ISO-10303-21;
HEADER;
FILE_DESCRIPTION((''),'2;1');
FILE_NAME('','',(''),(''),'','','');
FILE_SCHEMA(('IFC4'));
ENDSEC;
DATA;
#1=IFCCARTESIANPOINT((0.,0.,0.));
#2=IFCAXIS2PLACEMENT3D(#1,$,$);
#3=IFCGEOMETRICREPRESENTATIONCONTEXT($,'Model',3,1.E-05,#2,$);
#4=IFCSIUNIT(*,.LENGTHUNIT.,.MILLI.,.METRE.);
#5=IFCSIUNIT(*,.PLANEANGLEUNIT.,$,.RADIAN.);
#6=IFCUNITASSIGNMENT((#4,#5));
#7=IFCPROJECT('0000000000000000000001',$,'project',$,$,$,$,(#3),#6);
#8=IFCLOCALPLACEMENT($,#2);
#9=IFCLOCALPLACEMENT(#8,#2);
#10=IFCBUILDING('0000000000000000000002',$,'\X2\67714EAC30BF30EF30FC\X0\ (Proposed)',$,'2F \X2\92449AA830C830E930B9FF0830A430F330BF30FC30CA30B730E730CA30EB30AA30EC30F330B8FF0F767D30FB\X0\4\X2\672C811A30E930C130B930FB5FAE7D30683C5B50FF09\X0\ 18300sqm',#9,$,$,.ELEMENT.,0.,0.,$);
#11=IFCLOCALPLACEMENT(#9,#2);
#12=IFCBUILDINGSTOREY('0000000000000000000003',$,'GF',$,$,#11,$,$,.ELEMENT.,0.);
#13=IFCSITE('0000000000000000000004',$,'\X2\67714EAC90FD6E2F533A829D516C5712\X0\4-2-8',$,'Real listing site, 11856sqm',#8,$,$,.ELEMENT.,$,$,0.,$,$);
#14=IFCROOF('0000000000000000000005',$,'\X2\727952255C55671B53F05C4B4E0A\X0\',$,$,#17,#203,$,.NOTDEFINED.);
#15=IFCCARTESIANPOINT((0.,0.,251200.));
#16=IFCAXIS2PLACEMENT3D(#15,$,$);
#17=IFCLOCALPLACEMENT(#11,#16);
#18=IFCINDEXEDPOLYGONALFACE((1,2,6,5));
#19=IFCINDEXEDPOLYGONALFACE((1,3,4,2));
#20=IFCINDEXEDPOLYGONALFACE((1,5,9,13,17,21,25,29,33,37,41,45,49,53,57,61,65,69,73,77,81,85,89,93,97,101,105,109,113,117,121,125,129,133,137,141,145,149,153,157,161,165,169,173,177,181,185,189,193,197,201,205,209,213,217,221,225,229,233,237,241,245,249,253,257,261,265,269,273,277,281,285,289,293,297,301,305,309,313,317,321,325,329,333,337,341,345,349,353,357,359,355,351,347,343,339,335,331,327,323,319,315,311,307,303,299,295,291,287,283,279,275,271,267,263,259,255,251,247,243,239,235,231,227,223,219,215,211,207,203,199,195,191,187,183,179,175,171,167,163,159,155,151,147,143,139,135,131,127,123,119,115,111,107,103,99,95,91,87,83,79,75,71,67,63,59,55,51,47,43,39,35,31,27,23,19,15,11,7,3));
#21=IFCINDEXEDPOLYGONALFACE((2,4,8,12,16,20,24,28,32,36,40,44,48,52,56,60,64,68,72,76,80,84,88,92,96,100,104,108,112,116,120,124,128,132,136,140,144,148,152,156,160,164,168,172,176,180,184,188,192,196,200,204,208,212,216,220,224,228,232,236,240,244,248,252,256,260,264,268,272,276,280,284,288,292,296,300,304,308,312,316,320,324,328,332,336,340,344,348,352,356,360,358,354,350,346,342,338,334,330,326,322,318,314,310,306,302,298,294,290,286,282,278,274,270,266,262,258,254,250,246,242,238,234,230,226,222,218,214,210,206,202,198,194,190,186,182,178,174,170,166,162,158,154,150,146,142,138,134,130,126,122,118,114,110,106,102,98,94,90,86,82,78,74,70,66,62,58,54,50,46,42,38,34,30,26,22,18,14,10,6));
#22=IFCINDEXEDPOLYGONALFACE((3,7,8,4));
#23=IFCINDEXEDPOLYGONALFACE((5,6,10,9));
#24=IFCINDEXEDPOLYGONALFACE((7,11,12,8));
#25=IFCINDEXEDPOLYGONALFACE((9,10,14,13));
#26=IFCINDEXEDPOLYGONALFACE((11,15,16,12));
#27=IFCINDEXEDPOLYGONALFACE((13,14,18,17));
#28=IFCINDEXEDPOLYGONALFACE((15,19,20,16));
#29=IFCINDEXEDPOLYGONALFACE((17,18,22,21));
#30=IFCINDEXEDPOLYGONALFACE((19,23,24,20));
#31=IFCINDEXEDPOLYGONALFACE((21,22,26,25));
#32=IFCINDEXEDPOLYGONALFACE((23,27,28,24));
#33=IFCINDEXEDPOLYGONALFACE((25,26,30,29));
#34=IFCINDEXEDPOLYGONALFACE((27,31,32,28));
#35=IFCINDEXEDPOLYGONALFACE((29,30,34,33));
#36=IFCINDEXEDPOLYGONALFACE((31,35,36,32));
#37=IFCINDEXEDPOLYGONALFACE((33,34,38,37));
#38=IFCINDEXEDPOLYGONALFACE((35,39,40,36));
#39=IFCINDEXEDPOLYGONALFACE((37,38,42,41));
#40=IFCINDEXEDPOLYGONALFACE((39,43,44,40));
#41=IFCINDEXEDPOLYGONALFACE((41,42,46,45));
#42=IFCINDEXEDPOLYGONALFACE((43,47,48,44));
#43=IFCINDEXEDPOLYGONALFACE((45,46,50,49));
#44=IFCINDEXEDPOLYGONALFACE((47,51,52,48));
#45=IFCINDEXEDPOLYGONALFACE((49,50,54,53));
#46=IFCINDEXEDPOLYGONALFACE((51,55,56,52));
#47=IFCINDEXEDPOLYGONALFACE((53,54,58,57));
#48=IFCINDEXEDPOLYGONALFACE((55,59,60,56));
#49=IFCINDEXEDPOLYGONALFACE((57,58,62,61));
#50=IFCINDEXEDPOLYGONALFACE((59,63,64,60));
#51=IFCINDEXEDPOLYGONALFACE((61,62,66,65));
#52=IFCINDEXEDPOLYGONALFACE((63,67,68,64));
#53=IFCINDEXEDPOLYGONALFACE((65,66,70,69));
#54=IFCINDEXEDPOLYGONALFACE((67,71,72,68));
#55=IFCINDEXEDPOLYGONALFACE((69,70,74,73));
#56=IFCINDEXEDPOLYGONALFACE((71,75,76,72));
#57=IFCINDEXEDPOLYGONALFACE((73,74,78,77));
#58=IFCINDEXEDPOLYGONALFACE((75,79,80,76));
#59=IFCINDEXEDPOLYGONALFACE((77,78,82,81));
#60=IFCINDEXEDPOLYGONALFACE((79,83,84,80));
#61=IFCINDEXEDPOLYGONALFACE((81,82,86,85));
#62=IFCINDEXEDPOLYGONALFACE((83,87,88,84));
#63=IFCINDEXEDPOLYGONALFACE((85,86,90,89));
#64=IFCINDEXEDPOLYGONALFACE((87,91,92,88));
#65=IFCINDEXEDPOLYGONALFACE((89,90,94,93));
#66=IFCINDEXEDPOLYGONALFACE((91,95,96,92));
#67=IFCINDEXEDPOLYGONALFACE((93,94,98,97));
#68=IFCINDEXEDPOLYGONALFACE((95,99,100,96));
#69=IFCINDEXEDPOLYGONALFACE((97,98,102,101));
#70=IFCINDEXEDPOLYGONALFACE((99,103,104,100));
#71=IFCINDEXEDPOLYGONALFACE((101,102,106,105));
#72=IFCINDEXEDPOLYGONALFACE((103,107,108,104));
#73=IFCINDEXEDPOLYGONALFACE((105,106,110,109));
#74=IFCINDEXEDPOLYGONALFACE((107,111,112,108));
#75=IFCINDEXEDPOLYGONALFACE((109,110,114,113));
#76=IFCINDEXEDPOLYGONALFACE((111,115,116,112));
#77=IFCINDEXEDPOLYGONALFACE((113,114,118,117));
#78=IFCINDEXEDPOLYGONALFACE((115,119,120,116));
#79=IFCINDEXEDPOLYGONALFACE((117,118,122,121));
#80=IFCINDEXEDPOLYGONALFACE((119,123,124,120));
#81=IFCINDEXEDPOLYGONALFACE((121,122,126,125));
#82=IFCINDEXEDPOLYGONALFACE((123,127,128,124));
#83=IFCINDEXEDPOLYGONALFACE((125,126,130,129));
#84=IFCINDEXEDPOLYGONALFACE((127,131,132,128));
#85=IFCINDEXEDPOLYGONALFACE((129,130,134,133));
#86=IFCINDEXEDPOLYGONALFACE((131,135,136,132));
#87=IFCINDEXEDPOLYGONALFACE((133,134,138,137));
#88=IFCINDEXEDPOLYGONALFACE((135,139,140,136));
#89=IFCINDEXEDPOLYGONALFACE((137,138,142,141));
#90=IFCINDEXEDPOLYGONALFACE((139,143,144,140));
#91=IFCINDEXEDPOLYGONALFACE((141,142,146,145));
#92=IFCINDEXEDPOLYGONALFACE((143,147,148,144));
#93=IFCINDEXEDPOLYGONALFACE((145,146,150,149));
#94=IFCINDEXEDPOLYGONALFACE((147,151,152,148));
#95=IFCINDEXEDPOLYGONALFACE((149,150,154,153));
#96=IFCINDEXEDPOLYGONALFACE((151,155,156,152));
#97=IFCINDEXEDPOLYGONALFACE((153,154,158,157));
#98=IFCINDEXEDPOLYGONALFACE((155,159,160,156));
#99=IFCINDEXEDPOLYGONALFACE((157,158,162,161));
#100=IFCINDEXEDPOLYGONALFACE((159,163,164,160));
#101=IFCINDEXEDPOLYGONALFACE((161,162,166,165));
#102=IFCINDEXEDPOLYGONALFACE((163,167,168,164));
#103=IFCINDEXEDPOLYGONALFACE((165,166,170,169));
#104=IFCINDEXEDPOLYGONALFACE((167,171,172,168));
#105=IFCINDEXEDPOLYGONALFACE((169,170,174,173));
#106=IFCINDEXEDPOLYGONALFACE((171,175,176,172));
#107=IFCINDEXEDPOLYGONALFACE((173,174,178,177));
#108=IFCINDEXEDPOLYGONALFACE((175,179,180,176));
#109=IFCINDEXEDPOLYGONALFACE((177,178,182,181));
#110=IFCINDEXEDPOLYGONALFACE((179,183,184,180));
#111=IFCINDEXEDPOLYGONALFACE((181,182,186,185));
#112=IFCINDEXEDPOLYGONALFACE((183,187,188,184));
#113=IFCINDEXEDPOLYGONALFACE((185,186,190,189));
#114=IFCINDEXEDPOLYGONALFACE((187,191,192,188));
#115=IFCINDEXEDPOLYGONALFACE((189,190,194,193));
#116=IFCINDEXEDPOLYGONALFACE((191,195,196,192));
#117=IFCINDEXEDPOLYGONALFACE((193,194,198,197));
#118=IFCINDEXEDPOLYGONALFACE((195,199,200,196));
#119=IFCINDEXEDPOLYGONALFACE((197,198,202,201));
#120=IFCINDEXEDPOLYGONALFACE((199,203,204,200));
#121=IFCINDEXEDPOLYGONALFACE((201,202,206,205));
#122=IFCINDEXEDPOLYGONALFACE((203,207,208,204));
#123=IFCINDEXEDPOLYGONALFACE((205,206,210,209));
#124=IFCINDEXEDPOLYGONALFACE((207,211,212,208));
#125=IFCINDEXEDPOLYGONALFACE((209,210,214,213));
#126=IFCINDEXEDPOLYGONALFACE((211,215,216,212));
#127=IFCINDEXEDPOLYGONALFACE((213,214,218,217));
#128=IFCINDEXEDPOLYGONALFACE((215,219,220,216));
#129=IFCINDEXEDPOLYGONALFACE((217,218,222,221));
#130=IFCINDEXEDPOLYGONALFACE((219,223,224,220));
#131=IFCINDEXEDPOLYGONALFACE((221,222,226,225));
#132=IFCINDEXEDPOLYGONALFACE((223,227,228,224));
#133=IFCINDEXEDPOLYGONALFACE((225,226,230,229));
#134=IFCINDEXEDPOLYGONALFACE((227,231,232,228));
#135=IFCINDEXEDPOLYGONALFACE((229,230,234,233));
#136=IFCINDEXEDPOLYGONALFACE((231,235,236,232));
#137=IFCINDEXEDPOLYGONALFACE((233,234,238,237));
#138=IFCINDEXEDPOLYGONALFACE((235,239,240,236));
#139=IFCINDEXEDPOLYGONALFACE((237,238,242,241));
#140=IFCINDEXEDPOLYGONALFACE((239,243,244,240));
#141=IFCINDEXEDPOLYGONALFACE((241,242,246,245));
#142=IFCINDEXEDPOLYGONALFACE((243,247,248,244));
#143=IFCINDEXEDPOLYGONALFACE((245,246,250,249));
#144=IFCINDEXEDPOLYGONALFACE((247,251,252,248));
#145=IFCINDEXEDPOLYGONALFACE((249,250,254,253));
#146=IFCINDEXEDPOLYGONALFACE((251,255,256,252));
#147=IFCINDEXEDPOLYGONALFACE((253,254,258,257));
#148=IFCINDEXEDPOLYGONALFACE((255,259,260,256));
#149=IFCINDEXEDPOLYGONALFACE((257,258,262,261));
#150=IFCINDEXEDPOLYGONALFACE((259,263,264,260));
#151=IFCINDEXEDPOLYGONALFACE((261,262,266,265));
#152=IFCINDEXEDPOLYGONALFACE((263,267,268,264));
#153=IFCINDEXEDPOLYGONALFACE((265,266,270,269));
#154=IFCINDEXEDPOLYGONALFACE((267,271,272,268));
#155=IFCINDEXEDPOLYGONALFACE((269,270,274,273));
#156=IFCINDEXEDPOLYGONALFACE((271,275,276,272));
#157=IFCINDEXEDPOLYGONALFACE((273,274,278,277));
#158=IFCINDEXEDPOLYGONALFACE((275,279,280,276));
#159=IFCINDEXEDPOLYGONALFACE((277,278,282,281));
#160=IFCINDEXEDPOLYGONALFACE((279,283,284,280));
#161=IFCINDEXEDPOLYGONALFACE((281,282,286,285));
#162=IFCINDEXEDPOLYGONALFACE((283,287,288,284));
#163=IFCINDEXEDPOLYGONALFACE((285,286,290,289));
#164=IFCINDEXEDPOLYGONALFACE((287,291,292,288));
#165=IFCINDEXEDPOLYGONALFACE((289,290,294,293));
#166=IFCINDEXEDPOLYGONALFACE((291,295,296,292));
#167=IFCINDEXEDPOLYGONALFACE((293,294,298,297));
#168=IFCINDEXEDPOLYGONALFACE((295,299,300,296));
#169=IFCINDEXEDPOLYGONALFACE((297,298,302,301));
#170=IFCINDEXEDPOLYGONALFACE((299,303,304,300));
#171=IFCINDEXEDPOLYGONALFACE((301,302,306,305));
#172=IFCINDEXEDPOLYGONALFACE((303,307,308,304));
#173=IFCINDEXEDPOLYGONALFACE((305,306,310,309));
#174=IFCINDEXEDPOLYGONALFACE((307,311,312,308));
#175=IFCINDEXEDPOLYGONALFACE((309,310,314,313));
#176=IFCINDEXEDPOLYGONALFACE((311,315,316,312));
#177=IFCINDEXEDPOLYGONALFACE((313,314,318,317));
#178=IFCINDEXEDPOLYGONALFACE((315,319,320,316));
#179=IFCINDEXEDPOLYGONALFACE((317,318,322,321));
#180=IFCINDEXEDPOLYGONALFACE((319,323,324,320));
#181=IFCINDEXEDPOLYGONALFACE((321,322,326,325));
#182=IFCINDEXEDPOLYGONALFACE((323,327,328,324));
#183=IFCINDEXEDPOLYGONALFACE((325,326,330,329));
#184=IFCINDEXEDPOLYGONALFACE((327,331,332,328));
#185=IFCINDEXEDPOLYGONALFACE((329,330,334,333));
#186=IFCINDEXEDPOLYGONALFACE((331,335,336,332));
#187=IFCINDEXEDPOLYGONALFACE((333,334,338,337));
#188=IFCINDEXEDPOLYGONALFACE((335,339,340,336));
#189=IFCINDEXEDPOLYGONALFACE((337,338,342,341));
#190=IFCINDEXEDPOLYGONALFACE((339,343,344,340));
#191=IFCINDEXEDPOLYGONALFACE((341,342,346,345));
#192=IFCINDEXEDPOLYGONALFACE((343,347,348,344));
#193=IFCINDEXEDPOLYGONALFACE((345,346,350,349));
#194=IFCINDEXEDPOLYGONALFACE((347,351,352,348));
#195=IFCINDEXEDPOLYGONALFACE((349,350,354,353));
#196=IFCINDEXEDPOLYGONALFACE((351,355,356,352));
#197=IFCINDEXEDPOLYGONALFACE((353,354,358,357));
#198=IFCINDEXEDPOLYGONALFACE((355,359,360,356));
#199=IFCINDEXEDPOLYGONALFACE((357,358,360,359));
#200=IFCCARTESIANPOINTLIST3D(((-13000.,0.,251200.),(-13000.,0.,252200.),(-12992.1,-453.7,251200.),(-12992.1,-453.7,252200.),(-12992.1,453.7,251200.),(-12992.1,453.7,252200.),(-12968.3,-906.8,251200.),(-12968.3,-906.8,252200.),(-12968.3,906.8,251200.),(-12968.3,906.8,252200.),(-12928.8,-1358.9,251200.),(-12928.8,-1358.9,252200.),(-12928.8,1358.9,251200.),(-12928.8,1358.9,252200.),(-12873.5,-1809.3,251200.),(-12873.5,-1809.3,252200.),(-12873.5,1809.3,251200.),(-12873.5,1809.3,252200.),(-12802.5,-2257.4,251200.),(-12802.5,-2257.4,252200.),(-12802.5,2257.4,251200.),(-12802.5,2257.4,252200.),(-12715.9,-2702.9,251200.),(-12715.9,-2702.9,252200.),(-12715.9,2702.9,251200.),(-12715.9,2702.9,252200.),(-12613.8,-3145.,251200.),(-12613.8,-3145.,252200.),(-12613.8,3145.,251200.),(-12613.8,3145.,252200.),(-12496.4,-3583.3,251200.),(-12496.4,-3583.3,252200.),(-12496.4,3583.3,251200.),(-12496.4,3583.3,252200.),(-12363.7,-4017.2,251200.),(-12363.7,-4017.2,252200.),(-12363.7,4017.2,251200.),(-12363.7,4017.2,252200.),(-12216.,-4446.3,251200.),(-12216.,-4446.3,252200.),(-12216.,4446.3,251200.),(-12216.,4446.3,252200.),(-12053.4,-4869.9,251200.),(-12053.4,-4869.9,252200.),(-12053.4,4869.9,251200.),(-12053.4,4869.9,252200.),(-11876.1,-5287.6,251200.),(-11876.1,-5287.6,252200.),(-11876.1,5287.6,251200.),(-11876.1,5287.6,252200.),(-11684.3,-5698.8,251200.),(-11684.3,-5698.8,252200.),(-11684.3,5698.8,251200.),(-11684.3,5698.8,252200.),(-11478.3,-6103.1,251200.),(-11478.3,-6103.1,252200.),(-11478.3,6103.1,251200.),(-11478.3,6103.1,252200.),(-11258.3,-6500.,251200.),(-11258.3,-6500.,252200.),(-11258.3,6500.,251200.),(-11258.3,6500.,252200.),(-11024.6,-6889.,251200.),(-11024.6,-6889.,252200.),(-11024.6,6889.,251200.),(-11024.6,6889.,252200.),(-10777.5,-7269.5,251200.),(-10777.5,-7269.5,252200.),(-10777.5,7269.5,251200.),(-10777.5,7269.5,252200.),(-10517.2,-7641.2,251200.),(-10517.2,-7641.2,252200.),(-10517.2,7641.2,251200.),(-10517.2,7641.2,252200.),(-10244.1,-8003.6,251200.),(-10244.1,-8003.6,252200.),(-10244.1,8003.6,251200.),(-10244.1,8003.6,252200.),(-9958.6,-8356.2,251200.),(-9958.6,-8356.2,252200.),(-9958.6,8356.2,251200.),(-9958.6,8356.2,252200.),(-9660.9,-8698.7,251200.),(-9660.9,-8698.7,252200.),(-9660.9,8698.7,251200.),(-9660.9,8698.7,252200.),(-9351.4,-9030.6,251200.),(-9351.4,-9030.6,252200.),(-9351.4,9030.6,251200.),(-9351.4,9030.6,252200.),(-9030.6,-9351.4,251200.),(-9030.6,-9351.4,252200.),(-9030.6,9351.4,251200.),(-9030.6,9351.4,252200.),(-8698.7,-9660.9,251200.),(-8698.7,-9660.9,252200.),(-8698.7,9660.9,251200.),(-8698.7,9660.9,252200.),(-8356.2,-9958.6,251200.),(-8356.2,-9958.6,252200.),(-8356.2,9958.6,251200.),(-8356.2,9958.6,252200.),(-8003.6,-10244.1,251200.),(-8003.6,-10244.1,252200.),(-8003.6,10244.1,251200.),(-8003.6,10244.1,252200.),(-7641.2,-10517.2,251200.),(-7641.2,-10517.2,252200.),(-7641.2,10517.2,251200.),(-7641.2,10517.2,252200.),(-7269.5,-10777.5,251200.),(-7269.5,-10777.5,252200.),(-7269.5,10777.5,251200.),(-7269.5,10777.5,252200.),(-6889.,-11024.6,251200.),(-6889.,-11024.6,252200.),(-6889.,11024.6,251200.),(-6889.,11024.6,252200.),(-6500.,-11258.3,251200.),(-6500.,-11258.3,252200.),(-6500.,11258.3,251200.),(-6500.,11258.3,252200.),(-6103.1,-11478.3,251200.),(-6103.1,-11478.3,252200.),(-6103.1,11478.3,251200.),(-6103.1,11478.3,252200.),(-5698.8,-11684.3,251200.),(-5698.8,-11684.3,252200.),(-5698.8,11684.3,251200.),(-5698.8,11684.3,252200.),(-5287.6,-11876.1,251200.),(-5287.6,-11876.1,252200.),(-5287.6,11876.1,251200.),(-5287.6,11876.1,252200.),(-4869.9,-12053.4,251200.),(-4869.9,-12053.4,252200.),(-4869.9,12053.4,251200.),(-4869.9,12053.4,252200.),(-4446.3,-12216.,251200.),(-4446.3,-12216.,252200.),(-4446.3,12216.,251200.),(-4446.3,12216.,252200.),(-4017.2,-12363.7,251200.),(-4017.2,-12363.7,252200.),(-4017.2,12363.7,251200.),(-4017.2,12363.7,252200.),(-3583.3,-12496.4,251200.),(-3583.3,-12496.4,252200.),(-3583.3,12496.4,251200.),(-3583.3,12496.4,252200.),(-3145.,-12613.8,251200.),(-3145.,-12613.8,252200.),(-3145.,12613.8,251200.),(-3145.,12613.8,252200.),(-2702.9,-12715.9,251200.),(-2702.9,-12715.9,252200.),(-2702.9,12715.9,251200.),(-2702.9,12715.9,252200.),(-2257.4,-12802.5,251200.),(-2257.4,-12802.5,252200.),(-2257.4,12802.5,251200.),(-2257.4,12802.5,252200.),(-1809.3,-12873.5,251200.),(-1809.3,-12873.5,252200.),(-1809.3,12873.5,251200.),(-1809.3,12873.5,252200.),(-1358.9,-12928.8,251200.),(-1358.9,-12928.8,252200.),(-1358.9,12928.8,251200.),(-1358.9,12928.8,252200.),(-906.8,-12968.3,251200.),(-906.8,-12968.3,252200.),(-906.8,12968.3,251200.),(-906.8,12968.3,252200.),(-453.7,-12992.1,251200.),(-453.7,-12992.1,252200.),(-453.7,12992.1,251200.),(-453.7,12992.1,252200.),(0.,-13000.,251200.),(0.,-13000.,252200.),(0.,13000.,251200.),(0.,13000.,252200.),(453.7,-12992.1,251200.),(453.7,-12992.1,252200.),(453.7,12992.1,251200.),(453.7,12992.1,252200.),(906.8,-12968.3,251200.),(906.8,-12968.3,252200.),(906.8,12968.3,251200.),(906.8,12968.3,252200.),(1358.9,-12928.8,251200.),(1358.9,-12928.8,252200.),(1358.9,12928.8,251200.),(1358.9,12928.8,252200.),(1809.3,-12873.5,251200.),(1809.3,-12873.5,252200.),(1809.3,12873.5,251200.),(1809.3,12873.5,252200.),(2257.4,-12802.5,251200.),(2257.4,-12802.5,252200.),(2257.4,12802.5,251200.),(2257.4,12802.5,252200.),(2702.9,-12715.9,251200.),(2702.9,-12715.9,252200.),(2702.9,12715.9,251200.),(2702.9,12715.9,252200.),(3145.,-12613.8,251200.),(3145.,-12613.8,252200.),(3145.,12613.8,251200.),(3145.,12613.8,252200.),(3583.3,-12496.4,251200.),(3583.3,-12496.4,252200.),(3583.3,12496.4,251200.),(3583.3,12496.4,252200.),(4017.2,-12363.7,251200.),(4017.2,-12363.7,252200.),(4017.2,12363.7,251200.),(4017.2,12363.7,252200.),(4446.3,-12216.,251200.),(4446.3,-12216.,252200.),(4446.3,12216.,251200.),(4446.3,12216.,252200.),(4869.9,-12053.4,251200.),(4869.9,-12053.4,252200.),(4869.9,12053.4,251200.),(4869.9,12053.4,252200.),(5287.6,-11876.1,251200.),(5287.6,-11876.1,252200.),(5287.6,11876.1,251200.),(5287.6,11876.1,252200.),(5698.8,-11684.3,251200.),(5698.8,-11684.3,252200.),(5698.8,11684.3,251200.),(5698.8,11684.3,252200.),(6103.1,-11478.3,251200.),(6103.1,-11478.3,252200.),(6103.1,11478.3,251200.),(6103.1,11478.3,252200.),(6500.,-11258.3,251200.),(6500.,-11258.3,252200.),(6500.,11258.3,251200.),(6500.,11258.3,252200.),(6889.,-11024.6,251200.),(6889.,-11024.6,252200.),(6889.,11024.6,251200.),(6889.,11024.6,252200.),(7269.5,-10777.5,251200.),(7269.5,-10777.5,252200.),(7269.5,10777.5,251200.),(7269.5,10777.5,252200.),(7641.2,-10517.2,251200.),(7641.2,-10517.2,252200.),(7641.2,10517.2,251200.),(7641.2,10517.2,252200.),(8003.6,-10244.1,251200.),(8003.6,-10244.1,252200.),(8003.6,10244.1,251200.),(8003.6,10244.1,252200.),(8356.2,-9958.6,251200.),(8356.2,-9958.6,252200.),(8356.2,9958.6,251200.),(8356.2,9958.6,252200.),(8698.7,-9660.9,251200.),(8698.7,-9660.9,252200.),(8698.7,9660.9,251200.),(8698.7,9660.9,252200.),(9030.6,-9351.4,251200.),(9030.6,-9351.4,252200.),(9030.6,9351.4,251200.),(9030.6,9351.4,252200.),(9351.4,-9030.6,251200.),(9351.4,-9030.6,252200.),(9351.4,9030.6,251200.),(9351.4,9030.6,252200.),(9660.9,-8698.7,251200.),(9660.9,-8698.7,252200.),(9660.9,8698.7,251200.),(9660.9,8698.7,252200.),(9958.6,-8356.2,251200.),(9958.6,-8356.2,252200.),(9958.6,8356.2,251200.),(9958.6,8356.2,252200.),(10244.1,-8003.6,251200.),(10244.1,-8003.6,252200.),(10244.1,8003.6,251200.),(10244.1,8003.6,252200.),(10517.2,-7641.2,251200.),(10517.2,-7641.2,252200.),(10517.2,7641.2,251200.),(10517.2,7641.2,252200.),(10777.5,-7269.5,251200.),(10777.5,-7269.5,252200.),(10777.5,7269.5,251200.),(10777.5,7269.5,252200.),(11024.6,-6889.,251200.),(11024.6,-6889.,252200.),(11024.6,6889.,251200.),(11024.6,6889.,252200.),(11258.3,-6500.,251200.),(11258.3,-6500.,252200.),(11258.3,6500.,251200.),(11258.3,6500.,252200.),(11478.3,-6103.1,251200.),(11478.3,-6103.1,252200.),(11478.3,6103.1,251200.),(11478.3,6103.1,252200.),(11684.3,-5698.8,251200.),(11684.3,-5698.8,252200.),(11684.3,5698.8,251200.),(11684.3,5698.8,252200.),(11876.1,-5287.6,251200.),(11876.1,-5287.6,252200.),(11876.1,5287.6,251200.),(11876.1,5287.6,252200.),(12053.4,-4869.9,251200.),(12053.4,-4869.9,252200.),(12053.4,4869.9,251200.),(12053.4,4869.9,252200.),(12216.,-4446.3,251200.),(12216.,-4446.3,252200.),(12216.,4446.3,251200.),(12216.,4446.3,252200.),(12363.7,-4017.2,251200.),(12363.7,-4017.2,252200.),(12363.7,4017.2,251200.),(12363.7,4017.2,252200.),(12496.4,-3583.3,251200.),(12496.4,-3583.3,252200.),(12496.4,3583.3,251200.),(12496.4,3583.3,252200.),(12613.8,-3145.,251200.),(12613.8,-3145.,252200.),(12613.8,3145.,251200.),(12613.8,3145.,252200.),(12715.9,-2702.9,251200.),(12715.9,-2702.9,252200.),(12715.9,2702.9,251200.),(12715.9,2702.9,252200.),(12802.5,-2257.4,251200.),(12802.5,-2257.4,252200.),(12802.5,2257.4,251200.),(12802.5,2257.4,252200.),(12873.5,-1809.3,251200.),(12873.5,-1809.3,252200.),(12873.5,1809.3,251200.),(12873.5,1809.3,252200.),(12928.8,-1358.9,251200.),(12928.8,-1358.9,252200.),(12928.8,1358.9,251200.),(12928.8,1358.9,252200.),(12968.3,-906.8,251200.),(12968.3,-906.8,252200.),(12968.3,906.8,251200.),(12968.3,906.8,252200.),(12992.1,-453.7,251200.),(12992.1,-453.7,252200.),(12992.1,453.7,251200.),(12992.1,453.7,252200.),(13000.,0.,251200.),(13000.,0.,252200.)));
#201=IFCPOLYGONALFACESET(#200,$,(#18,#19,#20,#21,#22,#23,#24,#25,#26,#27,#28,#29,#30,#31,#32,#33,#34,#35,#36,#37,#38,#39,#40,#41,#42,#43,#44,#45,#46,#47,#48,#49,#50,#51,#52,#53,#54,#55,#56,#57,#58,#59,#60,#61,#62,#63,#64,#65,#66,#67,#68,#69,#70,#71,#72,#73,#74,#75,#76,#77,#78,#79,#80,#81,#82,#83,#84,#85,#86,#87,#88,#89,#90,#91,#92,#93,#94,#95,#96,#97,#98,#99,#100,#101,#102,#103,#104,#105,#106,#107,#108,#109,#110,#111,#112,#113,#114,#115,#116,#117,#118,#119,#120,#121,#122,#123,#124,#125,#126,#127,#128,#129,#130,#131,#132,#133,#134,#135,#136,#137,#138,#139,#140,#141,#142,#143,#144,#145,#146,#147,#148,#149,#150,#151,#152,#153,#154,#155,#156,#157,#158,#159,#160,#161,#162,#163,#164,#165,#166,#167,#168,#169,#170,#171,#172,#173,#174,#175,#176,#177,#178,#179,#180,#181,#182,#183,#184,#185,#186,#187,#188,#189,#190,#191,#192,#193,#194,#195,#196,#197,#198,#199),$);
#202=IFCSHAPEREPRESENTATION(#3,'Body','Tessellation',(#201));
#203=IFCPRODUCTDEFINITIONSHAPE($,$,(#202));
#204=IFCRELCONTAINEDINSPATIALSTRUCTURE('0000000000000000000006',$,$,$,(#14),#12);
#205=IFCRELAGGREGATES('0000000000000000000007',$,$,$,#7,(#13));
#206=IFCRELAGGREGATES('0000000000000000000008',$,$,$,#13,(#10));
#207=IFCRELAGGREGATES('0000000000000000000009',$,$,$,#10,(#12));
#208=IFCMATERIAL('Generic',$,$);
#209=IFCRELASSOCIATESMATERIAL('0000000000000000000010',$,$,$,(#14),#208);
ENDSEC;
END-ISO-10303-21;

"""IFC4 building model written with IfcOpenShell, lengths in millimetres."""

from ifc_helpers import new_model, si_unit, frame, origin, origin_2d, place, context, project, spatial, circle, extrude, material, element, save


model = new_model("IFC4")

# Units and contexts
model_context = context("Model", 3, precision=1e-05, world=origin())
ifc_project = project(units=[si_unit("LENGTHUNIT", "METRE", prefix="MILLI"), si_unit("PLANEANGLEUNIT", "RADIAN")], contexts=[model_context])

# Site, building, storey
site_placement = place(None, origin())
site = spatial("IfcSite", under=ifc_project, at=site_placement, Name="東京都港区芝公園4-2-8", ObjectType="Real listing site, 11856sqm", CompositionType="ELEMENT", RefElevation=0.0)
building_placement = place(site_placement, origin())
building = spatial("IfcBuilding", under=site, at=building_placement, Name="東京タワー (Proposed)", ObjectType="2F 鉄骨トラス（インターナショナルオレンジ／白・4本脚ラチス・微細格子） 18300sqm", CompositionType="ELEMENT", ElevationOfRefHeight=0.0, ElevationOfTerrain=0.0)
storey_placement = place(building_placement, origin())
storey = spatial("IfcBuildingStorey", under=building, at=storey_placement, Name="GF", CompositionType="ELEMENT", Elevation=0.0)

# Shared definitions
ifc_material = material(Name="Generic")

# Roof
roof_placement = place(storey_placement, frame((0.0, 0.0, 251200.0)))
element("IfcRoof", 1, at=roof_placement, inside=storey, material=ifc_material, Name="特別展望台屋上", PredefinedType="NOTDEFINED", context=model_context, shape_type="SweptSolid", body=[
    extrude(circle(Radius=13000.0, at=origin_2d()), frame((0.0, 0.0, 251200.0)), (0.0, 0.0, 1.0), 1000.0),
])

save(model, "model.ifc")
